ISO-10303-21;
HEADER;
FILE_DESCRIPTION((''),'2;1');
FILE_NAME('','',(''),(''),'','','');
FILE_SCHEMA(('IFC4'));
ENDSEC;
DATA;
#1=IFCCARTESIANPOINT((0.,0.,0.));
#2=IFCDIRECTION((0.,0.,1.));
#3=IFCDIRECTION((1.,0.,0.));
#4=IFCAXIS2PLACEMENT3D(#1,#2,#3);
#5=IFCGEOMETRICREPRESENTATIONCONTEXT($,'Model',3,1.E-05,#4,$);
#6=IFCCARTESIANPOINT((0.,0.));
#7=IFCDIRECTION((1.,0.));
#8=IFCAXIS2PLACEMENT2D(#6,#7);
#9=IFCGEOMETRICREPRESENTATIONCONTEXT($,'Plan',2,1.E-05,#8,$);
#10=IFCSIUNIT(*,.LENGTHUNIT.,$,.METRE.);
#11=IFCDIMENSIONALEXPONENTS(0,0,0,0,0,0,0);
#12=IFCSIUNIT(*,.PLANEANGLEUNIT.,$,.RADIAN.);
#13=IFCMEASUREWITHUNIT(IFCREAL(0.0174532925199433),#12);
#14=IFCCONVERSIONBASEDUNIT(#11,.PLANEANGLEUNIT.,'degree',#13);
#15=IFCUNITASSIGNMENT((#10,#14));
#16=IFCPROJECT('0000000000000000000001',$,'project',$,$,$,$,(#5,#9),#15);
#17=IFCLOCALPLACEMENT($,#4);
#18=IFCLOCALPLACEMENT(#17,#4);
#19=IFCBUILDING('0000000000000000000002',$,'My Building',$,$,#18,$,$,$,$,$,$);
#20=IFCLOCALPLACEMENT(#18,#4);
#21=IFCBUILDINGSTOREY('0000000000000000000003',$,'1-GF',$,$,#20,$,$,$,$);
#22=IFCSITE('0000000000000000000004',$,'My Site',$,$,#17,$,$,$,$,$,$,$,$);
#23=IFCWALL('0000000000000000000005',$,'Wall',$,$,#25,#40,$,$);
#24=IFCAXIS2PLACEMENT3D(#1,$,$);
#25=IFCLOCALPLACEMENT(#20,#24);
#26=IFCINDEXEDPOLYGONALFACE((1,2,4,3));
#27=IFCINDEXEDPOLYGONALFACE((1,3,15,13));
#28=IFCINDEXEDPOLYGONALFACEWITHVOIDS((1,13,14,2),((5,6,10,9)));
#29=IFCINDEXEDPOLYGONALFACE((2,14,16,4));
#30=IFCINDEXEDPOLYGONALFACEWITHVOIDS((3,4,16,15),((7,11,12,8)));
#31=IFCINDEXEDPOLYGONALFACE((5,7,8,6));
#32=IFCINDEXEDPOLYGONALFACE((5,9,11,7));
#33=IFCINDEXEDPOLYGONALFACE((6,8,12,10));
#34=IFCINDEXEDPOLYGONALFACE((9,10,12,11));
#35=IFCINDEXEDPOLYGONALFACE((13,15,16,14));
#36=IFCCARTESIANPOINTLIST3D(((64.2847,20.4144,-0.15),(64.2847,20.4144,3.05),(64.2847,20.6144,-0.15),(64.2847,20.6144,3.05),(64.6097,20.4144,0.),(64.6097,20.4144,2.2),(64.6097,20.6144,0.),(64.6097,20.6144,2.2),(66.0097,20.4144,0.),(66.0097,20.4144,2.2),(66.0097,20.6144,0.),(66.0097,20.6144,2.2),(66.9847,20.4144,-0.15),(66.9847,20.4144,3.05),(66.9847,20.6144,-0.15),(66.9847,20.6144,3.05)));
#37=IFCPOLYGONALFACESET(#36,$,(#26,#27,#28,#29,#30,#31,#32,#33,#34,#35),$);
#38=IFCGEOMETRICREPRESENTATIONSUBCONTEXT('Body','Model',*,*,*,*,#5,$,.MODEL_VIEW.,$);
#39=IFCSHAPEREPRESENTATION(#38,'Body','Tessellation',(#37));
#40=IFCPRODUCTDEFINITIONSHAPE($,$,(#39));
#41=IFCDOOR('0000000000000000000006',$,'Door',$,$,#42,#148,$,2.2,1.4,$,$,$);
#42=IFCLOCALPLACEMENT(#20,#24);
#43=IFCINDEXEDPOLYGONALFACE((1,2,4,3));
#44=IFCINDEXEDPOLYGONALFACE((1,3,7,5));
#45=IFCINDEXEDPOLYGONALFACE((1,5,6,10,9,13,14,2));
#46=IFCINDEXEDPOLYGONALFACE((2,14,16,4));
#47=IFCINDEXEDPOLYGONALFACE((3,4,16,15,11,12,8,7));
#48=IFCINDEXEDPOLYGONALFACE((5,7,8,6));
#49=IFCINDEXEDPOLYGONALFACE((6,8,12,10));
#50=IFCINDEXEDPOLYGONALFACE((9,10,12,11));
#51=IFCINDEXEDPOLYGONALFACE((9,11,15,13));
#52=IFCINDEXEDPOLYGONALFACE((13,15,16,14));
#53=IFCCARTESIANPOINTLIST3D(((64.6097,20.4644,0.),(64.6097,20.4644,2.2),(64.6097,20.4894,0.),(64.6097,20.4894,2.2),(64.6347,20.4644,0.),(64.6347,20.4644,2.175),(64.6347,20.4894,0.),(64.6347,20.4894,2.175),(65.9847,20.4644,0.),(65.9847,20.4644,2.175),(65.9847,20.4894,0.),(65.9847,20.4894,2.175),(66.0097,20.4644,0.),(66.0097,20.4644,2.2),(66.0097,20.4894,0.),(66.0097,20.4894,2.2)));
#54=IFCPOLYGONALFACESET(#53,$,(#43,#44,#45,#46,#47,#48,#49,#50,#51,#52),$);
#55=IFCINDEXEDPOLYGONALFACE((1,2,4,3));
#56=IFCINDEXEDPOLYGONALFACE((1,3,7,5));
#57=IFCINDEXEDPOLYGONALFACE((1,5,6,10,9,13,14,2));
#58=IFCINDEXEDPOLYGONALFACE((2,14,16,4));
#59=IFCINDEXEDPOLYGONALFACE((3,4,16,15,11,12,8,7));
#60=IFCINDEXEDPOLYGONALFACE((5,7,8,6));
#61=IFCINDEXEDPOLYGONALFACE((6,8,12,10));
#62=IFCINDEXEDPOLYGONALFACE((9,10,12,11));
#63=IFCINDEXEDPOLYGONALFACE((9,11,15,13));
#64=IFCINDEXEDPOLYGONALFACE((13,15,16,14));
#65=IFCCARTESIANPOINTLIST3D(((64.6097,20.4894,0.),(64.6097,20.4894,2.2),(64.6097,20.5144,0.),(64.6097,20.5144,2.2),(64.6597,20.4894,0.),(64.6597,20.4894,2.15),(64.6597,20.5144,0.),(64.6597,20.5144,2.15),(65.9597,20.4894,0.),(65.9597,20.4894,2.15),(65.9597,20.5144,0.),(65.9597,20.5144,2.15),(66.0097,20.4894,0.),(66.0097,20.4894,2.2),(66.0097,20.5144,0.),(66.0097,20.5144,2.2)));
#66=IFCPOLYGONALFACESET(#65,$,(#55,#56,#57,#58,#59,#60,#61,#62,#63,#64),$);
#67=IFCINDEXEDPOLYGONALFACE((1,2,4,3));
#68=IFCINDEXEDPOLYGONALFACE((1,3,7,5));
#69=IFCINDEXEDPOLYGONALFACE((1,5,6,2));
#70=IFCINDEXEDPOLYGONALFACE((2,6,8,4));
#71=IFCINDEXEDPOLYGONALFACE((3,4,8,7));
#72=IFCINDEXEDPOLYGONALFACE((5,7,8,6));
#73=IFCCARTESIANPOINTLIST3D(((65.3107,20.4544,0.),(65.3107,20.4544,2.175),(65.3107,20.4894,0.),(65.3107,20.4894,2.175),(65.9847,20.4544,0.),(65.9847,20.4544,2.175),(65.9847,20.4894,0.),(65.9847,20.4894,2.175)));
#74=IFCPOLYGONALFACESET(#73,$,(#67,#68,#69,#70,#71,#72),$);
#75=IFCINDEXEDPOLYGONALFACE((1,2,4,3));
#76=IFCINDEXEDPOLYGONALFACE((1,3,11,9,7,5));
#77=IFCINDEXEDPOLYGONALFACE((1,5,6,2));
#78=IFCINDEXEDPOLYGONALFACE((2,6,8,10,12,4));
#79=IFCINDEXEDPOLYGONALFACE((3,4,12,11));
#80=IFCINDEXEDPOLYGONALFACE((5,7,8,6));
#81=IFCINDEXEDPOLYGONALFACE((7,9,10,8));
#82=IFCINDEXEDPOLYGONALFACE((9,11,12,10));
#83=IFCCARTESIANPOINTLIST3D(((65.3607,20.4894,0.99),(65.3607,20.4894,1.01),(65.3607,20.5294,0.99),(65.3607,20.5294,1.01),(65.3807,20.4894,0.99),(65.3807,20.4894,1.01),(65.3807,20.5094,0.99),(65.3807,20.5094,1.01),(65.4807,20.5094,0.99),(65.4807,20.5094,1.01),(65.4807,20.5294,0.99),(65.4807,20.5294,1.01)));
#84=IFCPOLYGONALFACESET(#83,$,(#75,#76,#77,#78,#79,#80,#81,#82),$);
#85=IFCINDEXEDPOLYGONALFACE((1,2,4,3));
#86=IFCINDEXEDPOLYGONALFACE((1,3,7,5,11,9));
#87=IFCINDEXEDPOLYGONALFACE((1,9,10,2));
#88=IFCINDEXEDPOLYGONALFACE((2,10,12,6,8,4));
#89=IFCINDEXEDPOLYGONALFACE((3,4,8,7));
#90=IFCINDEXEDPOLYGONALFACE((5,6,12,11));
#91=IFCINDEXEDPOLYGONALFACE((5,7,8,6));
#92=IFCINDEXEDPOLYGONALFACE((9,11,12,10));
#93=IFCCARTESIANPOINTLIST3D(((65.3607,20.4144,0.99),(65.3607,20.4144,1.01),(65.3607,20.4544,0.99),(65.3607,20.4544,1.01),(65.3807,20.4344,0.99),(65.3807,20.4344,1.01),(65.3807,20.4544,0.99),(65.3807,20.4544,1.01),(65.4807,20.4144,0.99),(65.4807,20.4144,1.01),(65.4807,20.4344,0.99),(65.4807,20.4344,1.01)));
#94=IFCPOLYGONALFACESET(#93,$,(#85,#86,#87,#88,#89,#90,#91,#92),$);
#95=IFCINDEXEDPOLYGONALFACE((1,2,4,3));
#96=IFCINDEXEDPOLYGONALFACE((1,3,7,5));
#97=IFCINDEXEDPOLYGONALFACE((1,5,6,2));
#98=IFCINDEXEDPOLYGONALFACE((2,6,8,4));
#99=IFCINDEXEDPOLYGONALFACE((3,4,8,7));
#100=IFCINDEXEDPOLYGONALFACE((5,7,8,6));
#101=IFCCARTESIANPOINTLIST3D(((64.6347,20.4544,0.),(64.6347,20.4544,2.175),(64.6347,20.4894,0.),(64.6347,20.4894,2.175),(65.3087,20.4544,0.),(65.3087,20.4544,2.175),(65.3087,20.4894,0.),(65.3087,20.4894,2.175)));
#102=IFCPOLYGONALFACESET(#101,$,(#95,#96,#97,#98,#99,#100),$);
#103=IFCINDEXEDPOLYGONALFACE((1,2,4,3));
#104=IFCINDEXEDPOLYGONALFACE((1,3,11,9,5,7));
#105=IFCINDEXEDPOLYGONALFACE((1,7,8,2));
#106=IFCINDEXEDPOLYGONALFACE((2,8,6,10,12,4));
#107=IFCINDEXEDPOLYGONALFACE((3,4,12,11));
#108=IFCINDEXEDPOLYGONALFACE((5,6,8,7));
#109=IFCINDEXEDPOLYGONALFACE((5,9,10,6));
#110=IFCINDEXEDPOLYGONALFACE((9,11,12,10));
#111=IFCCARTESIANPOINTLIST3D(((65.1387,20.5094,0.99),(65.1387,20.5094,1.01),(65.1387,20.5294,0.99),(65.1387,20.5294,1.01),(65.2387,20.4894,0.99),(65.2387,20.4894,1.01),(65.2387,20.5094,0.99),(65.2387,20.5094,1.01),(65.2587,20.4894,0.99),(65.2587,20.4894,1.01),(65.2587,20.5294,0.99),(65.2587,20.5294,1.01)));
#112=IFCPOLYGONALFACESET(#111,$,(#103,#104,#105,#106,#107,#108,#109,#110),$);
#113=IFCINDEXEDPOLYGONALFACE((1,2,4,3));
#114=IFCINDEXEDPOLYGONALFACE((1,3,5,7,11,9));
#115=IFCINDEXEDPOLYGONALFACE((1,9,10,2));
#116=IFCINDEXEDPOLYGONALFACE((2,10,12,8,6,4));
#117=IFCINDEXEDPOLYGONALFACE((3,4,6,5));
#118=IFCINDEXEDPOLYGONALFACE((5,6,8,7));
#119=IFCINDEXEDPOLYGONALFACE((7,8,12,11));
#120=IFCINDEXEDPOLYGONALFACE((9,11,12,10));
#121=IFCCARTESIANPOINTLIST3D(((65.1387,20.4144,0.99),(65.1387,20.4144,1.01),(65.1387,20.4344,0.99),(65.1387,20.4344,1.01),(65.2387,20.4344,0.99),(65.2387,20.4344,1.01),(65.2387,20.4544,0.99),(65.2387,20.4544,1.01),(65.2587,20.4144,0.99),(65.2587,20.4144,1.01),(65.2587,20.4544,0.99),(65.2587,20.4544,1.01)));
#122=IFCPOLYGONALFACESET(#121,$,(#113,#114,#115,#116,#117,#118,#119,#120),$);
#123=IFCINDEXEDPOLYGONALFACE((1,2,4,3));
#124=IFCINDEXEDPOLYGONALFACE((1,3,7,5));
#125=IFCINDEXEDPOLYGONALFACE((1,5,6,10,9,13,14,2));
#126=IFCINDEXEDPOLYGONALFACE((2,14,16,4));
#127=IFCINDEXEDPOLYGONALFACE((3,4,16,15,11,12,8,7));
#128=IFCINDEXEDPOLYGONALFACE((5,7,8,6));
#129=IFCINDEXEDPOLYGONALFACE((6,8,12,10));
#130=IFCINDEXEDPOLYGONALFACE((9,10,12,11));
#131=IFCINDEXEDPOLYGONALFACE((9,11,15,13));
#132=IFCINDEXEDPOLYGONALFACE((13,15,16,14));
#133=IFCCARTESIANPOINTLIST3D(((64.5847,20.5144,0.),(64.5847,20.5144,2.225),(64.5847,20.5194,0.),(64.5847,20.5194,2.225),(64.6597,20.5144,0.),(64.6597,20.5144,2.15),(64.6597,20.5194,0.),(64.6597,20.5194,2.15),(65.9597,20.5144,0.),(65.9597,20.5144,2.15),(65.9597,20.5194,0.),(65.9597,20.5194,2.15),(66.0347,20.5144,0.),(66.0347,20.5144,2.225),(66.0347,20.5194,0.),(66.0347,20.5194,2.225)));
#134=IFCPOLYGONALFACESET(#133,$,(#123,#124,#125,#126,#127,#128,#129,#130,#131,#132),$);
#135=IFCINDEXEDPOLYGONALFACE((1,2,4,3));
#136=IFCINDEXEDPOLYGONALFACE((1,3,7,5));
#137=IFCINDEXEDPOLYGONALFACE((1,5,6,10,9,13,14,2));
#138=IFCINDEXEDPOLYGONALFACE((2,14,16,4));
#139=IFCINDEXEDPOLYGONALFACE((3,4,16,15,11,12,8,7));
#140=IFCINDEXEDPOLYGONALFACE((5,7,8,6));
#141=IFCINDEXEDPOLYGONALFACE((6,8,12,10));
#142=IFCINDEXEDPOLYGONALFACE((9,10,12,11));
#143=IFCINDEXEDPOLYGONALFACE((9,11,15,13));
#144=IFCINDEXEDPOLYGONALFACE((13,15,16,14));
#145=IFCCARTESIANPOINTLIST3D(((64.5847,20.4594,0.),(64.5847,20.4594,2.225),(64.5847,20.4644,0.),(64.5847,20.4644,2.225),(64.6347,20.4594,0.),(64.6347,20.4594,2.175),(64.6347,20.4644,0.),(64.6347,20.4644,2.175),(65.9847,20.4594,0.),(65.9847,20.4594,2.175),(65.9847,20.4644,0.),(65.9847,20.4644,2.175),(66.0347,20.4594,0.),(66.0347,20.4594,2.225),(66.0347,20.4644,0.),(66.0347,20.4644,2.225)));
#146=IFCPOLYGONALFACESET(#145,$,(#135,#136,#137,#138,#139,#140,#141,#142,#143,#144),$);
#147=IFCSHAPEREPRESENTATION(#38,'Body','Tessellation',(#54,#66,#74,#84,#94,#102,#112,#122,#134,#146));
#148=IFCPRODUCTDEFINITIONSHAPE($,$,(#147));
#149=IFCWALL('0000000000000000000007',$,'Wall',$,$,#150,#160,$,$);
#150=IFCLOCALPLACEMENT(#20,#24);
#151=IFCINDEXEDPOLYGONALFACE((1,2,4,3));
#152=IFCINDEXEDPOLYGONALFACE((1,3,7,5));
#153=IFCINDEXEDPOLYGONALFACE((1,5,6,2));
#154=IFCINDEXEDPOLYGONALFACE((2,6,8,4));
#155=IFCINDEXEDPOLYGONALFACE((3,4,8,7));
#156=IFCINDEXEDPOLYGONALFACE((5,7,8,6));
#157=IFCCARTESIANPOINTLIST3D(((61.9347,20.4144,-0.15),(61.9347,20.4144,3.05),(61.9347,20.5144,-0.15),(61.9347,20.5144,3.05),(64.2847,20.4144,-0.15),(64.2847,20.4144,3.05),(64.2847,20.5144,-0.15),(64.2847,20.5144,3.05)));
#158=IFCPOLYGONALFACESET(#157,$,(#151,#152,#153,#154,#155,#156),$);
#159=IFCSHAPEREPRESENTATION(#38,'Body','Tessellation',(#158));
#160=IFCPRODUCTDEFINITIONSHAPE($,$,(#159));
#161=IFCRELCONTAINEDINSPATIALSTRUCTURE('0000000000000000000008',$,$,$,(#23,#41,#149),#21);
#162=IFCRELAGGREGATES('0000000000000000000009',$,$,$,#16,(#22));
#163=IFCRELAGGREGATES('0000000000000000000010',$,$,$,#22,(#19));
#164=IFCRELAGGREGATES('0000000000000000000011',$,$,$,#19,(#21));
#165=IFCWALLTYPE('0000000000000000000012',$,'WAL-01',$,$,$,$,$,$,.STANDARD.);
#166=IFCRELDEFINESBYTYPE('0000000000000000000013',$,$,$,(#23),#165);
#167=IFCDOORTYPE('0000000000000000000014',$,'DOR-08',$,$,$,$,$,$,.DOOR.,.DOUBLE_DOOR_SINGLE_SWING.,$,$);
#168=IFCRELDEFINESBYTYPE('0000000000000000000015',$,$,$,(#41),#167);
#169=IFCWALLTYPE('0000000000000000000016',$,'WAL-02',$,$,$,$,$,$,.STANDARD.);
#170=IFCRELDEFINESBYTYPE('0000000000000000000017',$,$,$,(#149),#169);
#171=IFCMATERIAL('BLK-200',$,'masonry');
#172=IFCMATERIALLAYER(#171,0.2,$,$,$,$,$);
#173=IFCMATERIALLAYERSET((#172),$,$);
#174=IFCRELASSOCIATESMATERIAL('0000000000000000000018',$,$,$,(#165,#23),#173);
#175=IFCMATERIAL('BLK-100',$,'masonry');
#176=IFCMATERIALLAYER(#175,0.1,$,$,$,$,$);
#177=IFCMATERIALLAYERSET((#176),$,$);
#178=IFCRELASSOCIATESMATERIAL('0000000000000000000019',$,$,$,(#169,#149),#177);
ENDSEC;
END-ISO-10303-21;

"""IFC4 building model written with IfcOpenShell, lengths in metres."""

from ifc_helpers import new_model, entity, si_unit, converted_unit, frame, origin_with_axes, origin_2d_with_axis, place, context, subcontext, project, spatial, line, indexed_curve, outline, extrude, shape, source, transform, mapped, material, layer, layer_set, layer_usage, type_object, type_shapes, element, fill, save


model = new_model("IFC4")

# Units and contexts
model_context = context("Model", 3, precision=1e-05, world=origin_with_axes())
plan_context = context("Plan", 2, precision=1e-05, world=origin_2d_with_axis())
body_context_1 = subcontext(model_context, "Body", "Model", "MODEL_VIEW")
body_context_2 = subcontext(plan_context, "Body", "Plan", "PLAN_VIEW")
ifc_project = project(units=[si_unit("LENGTHUNIT", "METRE"), converted_unit("PLANEANGLEUNIT", "degree", entity("IfcReal", 0.0174532925199433), si_unit("PLANEANGLEUNIT", "RADIAN"), dimensions=[0, 0, 0, 0, 0, 0, 0])], contexts=[model_context, plan_context])

# Site, building, storey
site_placement = place(None, origin_with_axes())
site = spatial("IfcSite", under=ifc_project, at=site_placement, Name="My Site")
building_placement = place(site_placement, origin_with_axes())
building = spatial("IfcBuilding", under=site, at=building_placement, Name="My Building")
storey_placement = place(building_placement, origin_with_axes())
storey = spatial("IfcBuildingStorey", under=building, at=storey_placement, Name="1-GF")

# Shared definitions
ifc_material_1 = material(Name="BLK-200", Category="masonry")
ifc_layer_1 = layer(ifc_material_1, 0.2)
ifc_layer_set_1 = layer_set([ifc_layer_1])
wall_type_1 = type_object("IfcWallType", Name="WAL-01", PredefinedType="STANDARD", material=ifc_layer_set_1)

# Wall, opening, door
ifc_layer_usage_1 = layer_usage(ifc_layer_set_1, "AXIS2", "POSITIVE", 0.0)
wall_1_placement = place(storey_placement, frame((66.9847, 20.6144, -0.15), z_axis=(0.0, 0.0, 1.0), x_axis=(-1.0, 0.000001, 0.0)))
wall_1 = element("IfcWall", 1, at=wall_1_placement, inside=storey, type_object=wall_type_1, material=ifc_layer_usage_1, Name="Wall", context=body_context_1, shape_type="SweptSolid", body=[
    extrude(outline(indexed_curve([(0.0, 0.0), (0.0, 0.2), (2.7, 0.2), (2.7, 0.0), (0.0, 0.0)], self_intersect=False)), origin_with_axes(), (0.0, 0.0, 1.0), 3.2),
])
shared_shape_1 = source(origin_with_axes(), body_context_1, "Body", "SweptSolid", [
    extrude(outline(indexed_curve([(0.0, 0.0), (1.4, 0.0), (1.4, 2.2), (0.0, 2.2)], segments=[line(1, 2, 3, 4, 1)])), frame((0.0, -0.6, 0.0), z_axis=(0.0, -1.0, 0.0), x_axis=(1.0, 0.0, 0.0)), (0.0, 0.0, -1.0), 1.2),
])
opening_1_placement = place(wall_1_placement, frame((0.975, 0.0, 0.15), z_axis=(0.0, 0.0, 1.0), x_axis=(1.0, 0.0, 0.0)))
opening_1 = element("IfcOpeningElement", 2, at=opening_1_placement, cuts=wall_1, PredefinedType="OPENING", context=body_context_1, shape_type="MappedRepresentation", body=[
    mapped(shared_shape_1, transform((0.0, 0.0, 0.0), x_axis=(1.0, 0.0, 0.0), y_axis=(0.0, 1.0, 0.0), z_axis=(0.0, 0.0, 1.0), scale=1.0)),
])
door_type_1 = type_object("IfcDoorType", Name="DOR-08", OperationType="DOUBLE_DOOR_SINGLE_SWING", PredefinedType="DOOR")
shared_shape_2 = source(origin_with_axes(), body_context_1, "Body", "SweptSolid", [
    extrude(outline(indexed_curve([(0.0, 0.0), (0.0, 2.2), (1.4, 2.2), (1.4, 0.0), (1.375, 0.0), (1.375, 2.175), (0.025, 2.175), (0.025, 0.0)], segments=[line(1, 2, 3, 4, 5, 6, 7, 8, 1)])), frame((0.0, 0.025, 0.0), z_axis=(0.0, -1.0, 0.0), x_axis=(1.0, 0.0, 0.0)), (0.0, 0.0, -1.0), 0.025),
    extrude(outline(indexed_curve([(0.0, 0.0), (0.0, 2.2), (1.4, 2.2), (1.4, 0.0), (1.35, 0.0), (1.35, 2.15), (0.05, 2.15), (0.05, 0.0)], segments=[line(1, 2, 3, 4, 5, 6, 7, 8, 1)])), frame((0.0, 0.0, 0.0), z_axis=(0.0, -1.0, 0.0), x_axis=(1.0, 0.0, 0.0)), (0.0, 0.0, -1.0), 0.025),
    extrude(outline(indexed_curve([(0.0, 0.0), (0.674, 0.0), (0.674, 0.035), (0.0, 0.035)], segments=[line(1, 2, 3, 4, 1)])), frame((0.025, 0.025, 0.0), z_axis=(0.0, 0.0, 1.0), x_axis=(1.0, 0.0, 0.0)), (0.0, 0.0, 1.0), 2.175),
    extrude(outline(indexed_curve([(0.0, 0.0), (0.0, -0.04), (-0.12, -0.04), (-0.12, -0.02), (-0.02, -0.02), (-0.02, 0.0)], segments=[line(1, 2, 3, 4, 5, 6, 1)])), frame((0.649, 0.025, 0.99), z_axis=(0.0, 0.0, 1.0), x_axis=(1.0, 0.0, 0.0)), (0.0, 0.0, 1.0), 0.02),
    extrude(outline(indexed_curve([(0.0, 0.0), (0.0, 0.04), (-0.12, 0.04), (-0.12, 0.02), (-0.02, 0.02), (-0.02, 0.0)], segments=[line(1, 2, 3, 4, 5, 6, 1)])), frame((0.649, 0.06, 0.99), z_axis=(0.0, 0.0, 1.0), x_axis=(1.0, 0.0, 0.0)), (0.0, 0.0, 1.0), 0.02),
    extrude(outline(indexed_curve([(0.0, 0.0), (-0.674, 0.0), (-0.674, 0.035), (0.0, 0.035)], segments=[line(1, 2, 3, 4, 1)])), frame((1.375, 0.025, 0.0), z_axis=(0.0, 0.0, 1.0), x_axis=(1.0, 0.0, 0.0)), (0.0, 0.0, 1.0), 2.175),
    extrude(outline(indexed_curve([(0.0, 0.0), (0.0, -0.04), (0.12, -0.04), (0.12, -0.02), (0.02, -0.02), (0.02, 0.0)], segments=[line(1, 2, 3, 4, 5, 6, 1)])), frame((0.751, 0.025, 0.99), z_axis=(0.0, 0.0, 1.0), x_axis=(1.0, 0.0, 0.0)), (0.0, 0.0, 1.0), 0.02),
    extrude(outline(indexed_curve([(0.0, 0.0), (0.0, 0.04), (0.12, 0.04), (0.12, 0.02), (0.02, 0.02), (0.02, 0.0)], segments=[line(1, 2, 3, 4, 5, 6, 1)])), frame((0.751, 0.06, 0.99), z_axis=(0.0, 0.0, 1.0), x_axis=(1.0, 0.0, 0.0)), (0.0, 0.0, 1.0), 0.02),
    extrude(outline(indexed_curve([(0.0, 0.0), (0.0, 2.225), (1.45, 2.225), (1.45, 0.0), (1.375, 0.0), (1.375, 2.15), (0.075, 2.15), (0.075, 0.0)], segments=[line(1, 2, 3, 4, 5, 6, 7, 8, 1)])), frame((-0.025, -0.005, 0.0), z_axis=(0.0, -1.0, 0.0), x_axis=(1.0, 0.0, 0.0)), (0.0, 0.0, -1.0), 0.005),
    extrude(outline(indexed_curve([(0.0, 0.0), (0.0, 2.225), (1.45, 2.225), (1.45, 0.0), (1.4, 0.0), (1.4, 2.175), (0.05, 2.175), (0.05, 0.0)], segments=[line(1, 2, 3, 4, 5, 6, 7, 8, 1)])), frame((-0.025, 0.05, 0.0), z_axis=(0.0, -1.0, 0.0), x_axis=(1.0, 0.0, 0.0)), (0.0, 0.0, -1.0), 0.005),
])
shared_shape_3 = source(origin_with_axes(), body_context_2, "Body", "Curve2D", [
    entity("IfcIndexedPolyCurve", entity("IfcCartesianPointList2D", [[0.0, 0.0], [0.0, 0.05], [0.025, 0.05], [0.025, 0.025], [0.05, 0.025], [0.05, 0.0]]), [entity("IfcLineIndex", [1, 2, 3, 4, 5, 6, 1])]),
    entity("IfcIndexedPolyCurve", entity("IfcCartesianPointList2D", [[1.4, 0.0], [1.4, 0.05], [1.375, 0.05], [1.375, 0.025], [1.35, 0.025], [1.35, 0.0]]), [entity("IfcLineIndex", [1, 2, 3, 4, 5, 6, 1])]),
    entity("IfcTrimmedCurve", entity("IfcEllipse", entity("IfcAxis2Placement2D", entity("IfcCartesianPoint", [0.06, 0.05]), entity("IfcDirection", [1.0, 0.0])), 0.64, 0.675), [entity("IfcCartesianPoint", [0.7, 0.05])], [entity("IfcCartesianPoint", [0.06, 0.725])], True, "CARTESIAN"),
    entity("IfcIndexedPolyCurve", entity("IfcCartesianPointList2D", [[0.025, 0.05], [0.06, 0.05], [0.06, 0.725], [0.025, 0.725]]), [entity("IfcLineIndex", [1, 2, 3, 4, 1])]),
    entity("IfcTrimmedCurve", entity("IfcEllipse", entity("IfcAxis2Placement2D", entity("IfcCartesianPoint", [1.34, 0.05]), entity("IfcDirection", [1.0, 0.0])), 0.64, 0.675), [entity("IfcCartesianPoint", [1.34, 0.725])], [entity("IfcCartesianPoint", [0.7, 0.05])], True, "CARTESIAN"),
    entity("IfcIndexedPolyCurve", entity("IfcCartesianPointList2D", [[1.375, 0.05], [1.34, 0.05], [1.34, 0.725], [1.375, 0.725]]), [entity("IfcLineIndex", [1, 2, 3, 4, 1])]),
])
type_shapes(door_type_1, [shared_shape_2, shared_shape_3])
door_1_placement = place(opening_1_placement, frame((0.0, 0.1, 0.0), z_axis=(0.0, 0.0, 1.0), x_axis=(1.0, 0.0, 0.0)))
door_1 = element("IfcDoor", 3, at=door_1_placement, inside=storey, type_object=door_type_1, Name="Door", OverallHeight=2.2, OverallWidth=1.4, shapes=[
    shape(body_context_1, "Body", "MappedRepresentation", [mapped(shared_shape_2, transform((0.0, 0.0, 0.0), x_axis=(1.0, 0.0, 0.0), y_axis=(0.0, 1.0, 0.0), z_axis=(0.0, 0.0, 1.0), scale=1.0))]),
    shape(body_context_2, "Body", "MappedRepresentation", [mapped(shared_shape_3, transform((0.0, 0.0, 0.0), x_axis=(1.0, 0.0, 0.0), y_axis=(0.0, 1.0, 0.0), z_axis=(0.0, 0.0, 1.0), scale=1.0))]),
])
fill(opening_1, door_1)

# Shared definitions
ifc_material_2 = material(Name="BLK-100", Category="masonry")
ifc_layer_2 = layer(ifc_material_2, 0.1)
ifc_layer_set_2 = layer_set([ifc_layer_2])
wall_type_2 = type_object("IfcWallType", Name="WAL-02", PredefinedType="STANDARD", material=ifc_layer_set_2)

# Wall
ifc_layer_usage_2 = layer_usage(ifc_layer_set_2, "AXIS2", "POSITIVE", 0.0)
wall_2_placement = place(storey_placement, frame((61.9347, 20.4144, -0.15), z_axis=(0.0, 0.0, 1.0), x_axis=(1.0, 0.0, 0.0)))
element("IfcWall", 4, at=wall_2_placement, inside=storey, type_object=wall_type_2, material=ifc_layer_usage_2, Name="Wall", context=body_context_1, shape_type="SweptSolid", body=[
    extrude(outline(indexed_curve([(0.0, 0.0), (0.0, 0.1), (2.35, 0.1), (2.35, 0.0), (0.0, 0.0)], self_intersect=False)), origin_with_axes(), (0.0, 0.0, 1.0), 3.2),
])

save(model, "model.ifc")
